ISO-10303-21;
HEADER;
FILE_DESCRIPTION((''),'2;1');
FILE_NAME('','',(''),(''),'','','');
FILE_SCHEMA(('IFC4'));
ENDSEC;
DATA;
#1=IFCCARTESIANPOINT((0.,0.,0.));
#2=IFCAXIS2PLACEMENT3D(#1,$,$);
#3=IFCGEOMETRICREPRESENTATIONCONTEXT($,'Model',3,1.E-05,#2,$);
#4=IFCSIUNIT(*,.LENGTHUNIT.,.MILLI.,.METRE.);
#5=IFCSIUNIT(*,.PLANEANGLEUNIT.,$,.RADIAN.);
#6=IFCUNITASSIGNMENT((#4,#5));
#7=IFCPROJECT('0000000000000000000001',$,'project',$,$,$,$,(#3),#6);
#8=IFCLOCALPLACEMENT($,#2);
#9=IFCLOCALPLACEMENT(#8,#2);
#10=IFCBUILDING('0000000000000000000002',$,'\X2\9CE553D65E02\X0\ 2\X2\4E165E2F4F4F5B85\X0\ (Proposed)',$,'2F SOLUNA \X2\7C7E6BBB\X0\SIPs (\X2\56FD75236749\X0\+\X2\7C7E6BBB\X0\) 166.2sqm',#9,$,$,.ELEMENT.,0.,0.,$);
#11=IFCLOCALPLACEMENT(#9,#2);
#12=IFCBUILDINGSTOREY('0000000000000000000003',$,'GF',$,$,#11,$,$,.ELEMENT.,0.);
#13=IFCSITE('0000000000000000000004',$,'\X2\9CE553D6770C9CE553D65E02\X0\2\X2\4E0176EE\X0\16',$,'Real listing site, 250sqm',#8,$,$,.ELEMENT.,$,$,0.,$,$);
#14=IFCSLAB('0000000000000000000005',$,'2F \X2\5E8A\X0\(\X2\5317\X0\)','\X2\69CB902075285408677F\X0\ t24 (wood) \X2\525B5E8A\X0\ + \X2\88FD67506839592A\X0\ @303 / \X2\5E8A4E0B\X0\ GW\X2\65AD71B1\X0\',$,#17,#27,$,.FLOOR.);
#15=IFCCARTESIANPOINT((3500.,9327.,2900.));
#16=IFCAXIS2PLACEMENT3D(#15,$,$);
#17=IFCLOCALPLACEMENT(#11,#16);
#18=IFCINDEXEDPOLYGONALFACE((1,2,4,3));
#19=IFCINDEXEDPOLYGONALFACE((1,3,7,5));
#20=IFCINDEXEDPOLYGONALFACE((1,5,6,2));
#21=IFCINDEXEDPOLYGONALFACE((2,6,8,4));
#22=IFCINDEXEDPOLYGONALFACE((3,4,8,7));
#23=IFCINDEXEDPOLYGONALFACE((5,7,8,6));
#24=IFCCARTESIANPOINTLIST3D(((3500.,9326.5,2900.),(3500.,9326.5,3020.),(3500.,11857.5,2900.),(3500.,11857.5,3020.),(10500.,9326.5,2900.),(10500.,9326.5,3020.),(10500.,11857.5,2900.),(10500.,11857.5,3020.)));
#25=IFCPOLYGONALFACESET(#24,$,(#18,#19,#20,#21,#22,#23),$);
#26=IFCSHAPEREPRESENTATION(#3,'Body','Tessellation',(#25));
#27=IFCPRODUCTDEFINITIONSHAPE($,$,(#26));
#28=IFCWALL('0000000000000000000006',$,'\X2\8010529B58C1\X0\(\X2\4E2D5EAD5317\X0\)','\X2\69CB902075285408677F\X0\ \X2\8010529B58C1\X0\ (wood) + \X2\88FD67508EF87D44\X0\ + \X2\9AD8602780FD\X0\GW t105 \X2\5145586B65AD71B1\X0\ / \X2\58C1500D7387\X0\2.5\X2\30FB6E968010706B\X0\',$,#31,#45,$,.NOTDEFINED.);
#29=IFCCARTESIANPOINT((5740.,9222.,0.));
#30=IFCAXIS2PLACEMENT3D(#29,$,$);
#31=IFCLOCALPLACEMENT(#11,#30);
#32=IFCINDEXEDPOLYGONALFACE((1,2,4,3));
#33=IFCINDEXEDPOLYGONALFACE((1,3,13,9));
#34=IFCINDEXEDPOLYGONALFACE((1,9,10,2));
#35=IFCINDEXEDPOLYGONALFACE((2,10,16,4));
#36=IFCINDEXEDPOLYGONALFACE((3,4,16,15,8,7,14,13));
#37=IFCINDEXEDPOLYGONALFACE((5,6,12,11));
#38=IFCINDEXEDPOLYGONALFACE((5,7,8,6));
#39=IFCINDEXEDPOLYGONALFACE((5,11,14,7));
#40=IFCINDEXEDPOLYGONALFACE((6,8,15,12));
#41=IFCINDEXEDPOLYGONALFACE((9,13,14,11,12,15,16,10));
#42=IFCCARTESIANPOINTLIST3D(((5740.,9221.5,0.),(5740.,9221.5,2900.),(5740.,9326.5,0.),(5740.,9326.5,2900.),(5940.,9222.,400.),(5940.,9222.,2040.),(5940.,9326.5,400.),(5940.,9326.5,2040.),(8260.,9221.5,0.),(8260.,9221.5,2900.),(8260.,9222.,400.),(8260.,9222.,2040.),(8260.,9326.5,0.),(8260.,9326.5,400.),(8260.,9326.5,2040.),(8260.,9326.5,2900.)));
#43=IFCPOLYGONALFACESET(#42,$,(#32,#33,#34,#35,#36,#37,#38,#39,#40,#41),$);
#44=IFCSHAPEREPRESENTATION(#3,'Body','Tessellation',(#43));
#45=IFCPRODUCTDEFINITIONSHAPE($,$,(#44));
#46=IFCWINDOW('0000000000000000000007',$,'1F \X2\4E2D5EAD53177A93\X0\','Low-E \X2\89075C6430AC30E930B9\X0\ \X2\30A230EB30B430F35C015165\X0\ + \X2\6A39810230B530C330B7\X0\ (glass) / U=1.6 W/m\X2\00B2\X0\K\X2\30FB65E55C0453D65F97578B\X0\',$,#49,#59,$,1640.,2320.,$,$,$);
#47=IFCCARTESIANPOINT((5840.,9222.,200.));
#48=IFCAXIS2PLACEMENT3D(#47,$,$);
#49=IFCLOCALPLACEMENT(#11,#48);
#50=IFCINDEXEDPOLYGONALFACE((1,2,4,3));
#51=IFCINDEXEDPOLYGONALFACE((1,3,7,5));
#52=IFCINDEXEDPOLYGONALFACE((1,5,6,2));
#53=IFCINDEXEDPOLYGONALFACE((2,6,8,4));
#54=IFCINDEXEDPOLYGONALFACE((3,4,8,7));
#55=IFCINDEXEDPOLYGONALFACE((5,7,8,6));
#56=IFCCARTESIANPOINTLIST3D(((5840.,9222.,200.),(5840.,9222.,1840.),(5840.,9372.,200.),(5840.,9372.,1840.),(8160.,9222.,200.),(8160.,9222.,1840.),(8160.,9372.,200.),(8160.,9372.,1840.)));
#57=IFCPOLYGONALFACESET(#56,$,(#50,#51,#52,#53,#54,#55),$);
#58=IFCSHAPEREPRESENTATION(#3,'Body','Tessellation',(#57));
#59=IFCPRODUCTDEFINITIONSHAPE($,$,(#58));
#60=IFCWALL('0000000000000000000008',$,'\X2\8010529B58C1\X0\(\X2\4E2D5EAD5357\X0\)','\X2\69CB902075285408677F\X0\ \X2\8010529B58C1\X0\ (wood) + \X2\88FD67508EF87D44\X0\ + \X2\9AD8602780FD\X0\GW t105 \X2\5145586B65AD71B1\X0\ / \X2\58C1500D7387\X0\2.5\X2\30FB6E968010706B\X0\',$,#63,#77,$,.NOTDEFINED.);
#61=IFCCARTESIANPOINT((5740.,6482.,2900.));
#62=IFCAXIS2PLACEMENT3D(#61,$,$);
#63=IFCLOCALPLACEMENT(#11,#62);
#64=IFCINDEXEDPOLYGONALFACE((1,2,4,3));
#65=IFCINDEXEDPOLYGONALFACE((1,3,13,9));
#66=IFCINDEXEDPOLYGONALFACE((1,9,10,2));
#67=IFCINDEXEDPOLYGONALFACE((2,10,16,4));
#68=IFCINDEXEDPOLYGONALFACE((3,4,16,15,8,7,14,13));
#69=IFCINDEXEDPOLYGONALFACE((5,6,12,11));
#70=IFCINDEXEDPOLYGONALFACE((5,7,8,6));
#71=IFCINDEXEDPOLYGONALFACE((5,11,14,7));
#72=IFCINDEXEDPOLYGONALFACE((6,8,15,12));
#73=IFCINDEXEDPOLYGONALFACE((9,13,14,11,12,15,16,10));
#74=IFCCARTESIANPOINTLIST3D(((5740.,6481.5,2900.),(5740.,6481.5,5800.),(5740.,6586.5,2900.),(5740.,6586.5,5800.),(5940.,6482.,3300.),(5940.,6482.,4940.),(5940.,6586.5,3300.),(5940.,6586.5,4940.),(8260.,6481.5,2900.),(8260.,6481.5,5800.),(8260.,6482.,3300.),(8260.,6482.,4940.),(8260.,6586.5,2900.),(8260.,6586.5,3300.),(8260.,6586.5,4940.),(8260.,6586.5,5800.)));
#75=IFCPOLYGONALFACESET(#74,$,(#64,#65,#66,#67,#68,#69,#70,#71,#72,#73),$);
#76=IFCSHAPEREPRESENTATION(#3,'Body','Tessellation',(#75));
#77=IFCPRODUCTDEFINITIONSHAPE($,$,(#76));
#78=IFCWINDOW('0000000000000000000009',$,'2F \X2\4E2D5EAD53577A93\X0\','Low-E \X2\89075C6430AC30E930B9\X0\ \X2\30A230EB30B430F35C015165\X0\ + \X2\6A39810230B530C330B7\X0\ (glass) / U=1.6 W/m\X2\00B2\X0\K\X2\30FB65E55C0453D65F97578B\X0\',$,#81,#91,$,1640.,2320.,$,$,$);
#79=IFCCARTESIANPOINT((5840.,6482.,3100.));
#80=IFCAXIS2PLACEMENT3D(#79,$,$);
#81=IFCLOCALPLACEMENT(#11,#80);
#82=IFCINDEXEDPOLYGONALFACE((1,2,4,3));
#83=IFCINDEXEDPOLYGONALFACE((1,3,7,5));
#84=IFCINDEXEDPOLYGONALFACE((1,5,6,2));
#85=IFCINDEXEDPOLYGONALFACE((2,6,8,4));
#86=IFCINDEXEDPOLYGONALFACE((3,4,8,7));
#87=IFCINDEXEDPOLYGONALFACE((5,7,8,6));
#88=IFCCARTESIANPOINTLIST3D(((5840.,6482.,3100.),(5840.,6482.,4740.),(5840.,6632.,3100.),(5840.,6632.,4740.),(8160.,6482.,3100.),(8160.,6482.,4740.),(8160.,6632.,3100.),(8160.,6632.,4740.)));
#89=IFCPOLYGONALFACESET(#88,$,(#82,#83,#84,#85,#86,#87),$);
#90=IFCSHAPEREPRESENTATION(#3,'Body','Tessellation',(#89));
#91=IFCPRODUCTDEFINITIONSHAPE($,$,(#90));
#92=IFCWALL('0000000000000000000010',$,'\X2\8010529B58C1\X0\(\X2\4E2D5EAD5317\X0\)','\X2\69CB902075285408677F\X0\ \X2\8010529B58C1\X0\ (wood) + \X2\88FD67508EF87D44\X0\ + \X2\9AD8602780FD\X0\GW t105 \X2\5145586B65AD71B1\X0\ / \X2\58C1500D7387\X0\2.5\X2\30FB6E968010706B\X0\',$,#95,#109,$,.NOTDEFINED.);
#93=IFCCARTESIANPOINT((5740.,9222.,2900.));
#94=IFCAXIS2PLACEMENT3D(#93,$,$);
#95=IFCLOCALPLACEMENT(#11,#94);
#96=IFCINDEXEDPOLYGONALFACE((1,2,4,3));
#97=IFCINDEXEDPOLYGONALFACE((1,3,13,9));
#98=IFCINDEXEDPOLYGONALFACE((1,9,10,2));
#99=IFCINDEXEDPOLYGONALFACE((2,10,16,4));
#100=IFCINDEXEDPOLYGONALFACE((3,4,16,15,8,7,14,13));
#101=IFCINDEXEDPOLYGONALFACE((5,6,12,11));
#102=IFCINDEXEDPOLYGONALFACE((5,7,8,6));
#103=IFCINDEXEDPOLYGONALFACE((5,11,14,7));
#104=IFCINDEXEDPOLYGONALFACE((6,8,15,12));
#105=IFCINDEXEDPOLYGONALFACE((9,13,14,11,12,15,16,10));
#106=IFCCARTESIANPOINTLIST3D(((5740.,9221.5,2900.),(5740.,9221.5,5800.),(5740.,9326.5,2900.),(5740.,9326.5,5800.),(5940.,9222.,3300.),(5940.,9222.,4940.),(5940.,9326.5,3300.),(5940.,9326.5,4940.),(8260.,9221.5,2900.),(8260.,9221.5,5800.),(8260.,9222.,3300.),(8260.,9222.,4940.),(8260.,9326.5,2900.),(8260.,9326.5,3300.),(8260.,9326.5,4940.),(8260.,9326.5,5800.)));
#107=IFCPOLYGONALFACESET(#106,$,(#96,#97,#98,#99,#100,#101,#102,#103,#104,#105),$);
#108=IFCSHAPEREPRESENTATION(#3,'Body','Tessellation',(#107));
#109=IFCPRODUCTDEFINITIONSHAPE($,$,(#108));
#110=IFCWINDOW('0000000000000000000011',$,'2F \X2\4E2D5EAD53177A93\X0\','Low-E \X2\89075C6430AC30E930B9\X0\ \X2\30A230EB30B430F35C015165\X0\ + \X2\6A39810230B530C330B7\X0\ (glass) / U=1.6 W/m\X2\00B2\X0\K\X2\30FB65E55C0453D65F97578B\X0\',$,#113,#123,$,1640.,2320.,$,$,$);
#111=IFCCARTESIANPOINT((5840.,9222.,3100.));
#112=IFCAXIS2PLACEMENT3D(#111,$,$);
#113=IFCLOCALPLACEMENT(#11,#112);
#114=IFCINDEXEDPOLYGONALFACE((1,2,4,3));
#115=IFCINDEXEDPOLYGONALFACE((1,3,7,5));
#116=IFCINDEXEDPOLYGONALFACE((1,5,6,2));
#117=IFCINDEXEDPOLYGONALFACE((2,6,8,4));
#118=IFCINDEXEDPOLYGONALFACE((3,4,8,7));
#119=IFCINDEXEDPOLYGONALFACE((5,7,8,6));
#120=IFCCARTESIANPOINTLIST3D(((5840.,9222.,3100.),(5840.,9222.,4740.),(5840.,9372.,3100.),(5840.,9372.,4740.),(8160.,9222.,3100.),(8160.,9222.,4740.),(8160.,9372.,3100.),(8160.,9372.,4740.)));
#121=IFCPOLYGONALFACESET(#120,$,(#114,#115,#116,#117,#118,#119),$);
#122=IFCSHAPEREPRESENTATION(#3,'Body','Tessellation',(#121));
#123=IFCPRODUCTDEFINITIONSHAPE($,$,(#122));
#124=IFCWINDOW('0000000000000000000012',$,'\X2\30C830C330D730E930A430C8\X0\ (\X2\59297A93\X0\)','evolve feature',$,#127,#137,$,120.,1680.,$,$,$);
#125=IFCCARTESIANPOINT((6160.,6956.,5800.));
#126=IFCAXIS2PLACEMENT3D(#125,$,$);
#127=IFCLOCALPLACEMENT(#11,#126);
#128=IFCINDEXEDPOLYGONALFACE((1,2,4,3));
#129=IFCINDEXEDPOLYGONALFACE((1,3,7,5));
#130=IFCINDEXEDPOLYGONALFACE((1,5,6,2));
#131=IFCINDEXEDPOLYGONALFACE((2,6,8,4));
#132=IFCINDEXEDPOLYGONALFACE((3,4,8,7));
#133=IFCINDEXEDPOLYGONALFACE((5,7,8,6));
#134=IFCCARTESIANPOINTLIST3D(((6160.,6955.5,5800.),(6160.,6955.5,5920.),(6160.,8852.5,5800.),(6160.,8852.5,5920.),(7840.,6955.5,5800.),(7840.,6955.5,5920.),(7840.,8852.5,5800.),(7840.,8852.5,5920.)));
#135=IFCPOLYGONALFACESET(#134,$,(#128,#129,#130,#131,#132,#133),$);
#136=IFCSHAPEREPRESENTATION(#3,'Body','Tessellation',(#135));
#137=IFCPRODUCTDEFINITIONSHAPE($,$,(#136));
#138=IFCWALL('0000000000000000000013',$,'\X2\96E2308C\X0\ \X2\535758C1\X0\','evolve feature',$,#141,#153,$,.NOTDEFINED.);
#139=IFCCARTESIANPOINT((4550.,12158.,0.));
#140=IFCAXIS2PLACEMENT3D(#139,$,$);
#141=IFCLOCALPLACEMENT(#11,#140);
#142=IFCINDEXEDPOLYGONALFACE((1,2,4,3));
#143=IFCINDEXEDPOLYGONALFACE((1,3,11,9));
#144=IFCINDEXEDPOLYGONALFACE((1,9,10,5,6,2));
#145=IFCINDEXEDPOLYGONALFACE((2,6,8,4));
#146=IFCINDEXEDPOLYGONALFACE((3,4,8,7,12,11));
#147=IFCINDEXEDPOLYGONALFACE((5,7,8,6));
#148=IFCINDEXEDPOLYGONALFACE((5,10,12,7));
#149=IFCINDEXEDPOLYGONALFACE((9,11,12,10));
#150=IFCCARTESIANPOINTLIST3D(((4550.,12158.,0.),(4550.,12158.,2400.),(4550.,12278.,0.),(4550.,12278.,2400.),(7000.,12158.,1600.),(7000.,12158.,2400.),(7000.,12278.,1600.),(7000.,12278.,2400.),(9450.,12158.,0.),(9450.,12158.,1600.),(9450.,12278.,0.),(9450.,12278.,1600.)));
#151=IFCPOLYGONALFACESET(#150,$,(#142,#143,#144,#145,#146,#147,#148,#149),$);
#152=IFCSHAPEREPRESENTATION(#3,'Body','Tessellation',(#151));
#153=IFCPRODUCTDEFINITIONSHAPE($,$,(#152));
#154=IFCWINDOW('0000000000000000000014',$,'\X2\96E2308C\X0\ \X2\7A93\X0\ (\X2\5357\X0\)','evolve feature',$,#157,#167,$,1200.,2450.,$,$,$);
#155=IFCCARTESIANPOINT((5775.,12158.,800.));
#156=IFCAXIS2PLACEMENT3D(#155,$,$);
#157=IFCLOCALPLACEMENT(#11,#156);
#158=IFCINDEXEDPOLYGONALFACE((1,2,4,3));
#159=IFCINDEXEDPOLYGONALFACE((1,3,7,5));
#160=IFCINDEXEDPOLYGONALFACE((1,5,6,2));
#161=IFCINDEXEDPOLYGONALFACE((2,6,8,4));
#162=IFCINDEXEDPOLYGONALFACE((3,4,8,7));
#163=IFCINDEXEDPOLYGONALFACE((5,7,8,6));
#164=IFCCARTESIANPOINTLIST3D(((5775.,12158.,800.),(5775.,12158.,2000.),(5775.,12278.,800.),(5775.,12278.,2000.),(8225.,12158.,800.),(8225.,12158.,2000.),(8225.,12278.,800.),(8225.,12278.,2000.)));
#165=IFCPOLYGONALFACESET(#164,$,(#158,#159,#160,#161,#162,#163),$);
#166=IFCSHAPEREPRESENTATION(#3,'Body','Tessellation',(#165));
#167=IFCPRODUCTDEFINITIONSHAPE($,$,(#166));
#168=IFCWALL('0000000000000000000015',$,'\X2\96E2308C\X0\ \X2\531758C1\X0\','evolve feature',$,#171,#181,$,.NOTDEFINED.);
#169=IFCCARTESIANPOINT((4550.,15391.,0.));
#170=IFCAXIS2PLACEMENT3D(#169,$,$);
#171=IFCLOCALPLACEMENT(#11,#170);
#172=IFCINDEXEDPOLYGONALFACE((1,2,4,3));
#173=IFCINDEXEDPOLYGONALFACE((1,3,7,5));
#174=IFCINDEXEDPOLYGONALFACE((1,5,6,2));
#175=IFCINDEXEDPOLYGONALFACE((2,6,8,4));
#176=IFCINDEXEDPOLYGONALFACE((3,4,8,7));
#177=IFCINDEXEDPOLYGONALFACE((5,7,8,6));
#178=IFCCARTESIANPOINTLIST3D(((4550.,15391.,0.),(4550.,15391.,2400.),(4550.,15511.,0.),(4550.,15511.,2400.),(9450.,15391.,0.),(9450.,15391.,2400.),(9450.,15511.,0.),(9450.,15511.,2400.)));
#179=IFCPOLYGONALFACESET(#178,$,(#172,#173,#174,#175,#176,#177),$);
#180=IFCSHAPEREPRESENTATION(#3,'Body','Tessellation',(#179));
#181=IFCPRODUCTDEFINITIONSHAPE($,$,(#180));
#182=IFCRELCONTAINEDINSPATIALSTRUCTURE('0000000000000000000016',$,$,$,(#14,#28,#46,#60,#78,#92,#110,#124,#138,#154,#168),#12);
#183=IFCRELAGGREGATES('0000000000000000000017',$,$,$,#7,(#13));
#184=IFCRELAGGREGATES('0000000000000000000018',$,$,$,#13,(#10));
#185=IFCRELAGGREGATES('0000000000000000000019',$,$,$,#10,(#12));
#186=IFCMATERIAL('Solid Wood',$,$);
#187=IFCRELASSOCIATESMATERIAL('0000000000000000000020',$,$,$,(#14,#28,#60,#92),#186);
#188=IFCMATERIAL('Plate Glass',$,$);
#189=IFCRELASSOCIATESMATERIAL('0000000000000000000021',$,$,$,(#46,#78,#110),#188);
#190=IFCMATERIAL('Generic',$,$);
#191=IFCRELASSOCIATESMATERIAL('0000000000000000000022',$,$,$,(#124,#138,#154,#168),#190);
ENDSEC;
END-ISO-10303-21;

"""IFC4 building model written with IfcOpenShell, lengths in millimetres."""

from ifc_helpers import new_model, si_unit, frame, frame_2d, origin, place, context, project, spatial, rectangle, extrude, material, element, fill, save


model = new_model("IFC4")

# Units and contexts
model_context = context("Model", 3, precision=1e-05, world=origin())
ifc_project = project(units=[si_unit("LENGTHUNIT", "METRE", prefix="MILLI"), si_unit("PLANEANGLEUNIT", "RADIAN")], contexts=[model_context])

# Site, building, storey
site_placement = place(None, origin())
site = spatial("IfcSite", under=ifc_project, at=site_placement, Name="鳥取県鳥取市2丁目16", ObjectType="Real listing site, 250sqm", CompositionType="ELEMENT", RefElevation=0.0)
building_placement = place(site_placement, origin())
building = spatial("IfcBuilding", under=site, at=building_placement, Name="鳥取市 2世帯住宅 (Proposed)", ObjectType="2F SOLUNA 籾殻SIPs (国産杉+籾殻) 166.2sqm", CompositionType="ELEMENT", ElevationOfRefHeight=0.0, ElevationOfTerrain=0.0)
storey_placement = place(building_placement, origin())
storey = spatial("IfcBuildingStorey", under=building, at=storey_placement, Name="GF", CompositionType="ELEMENT", Elevation=0.0)

# Slab
ifc_material_1 = material(Name="Solid Wood")
slab_1_placement = place(storey_placement, frame((3500.0, 9327.0, 2900.0)))
element("IfcSlab", 1, at=slab_1_placement, inside=storey, material=ifc_material_1, Name="2F 床(北)", Description="構造用合板 t24 (wood) 剛床 + 製材根太 @303 / 床下 GW断熱", PredefinedType="FLOOR", context=model_context, shape_type="SweptSolid", body=[
    extrude(rectangle(XDim=7000.0, YDim=2531.0, at=frame_2d((3500.0, 1265.0))), frame((3500.0, 9327.0, 2900.0)), (0.0, 0.0, 1.0), 120.0),
])
ifc_material_2 = material(Name="Generic")

# Wall, opening, window
wall_1_placement = place(storey_placement, frame((5740.0, 9222.0, 0.0)))
wall_1 = element("IfcWall", 2, at=wall_1_placement, inside=storey, material=ifc_material_1, Name="耐力壁(中庭北)", Description="構造用合板 耐力壁 (wood) + 製材軸組 + 高性能GW t105 充填断熱 / 壁倍率2.5・準耐火", PredefinedType="NOTDEFINED", context=model_context, shape_type="SweptSolid", body=[
    extrude(rectangle(XDim=2520.0, YDim=105.0, at=frame_2d((1260.0, 52.0))), frame((5740.0, 9222.0, 0.0)), (0.0, 0.0, 1.0), 2900.0),
])
opening_1_placement = place(storey_placement, frame((5840.0, 9222.0, 200.0)))
opening_1 = element("IfcOpeningElement", 3, at=opening_1_placement, cuts=wall_1, PredefinedType="NOTDEFINED", context=model_context, shape_type="SweptSolid", body=[
    extrude(rectangle(XDim=2320.0, YDim=150.0, at=frame_2d((1160.0, 75.0))), frame((5840.0, 9222.0, 200.0)), (0.0, 0.0, 1.0), 1640.0),
])
ifc_material_3 = material(Name="Plate Glass")
window_1_placement = place(storey_placement, frame((5840.0, 9222.0, 200.0)))
window_1 = element("IfcWindow", 4, at=window_1_placement, inside=storey, material=ifc_material_3, Name="1F 中庭北窓", Description="Low-E 複層ガラス アルゴン封入 + 樹脂サッシ (glass) / U=1.6 W/m²K・日射取得型", OverallHeight=1640.0, OverallWidth=2320.0, context=model_context, shape_type="SweptSolid", body=[
    extrude(rectangle(XDim=2320.0, YDim=150.0, at=frame_2d((1160.0, 75.0))), frame((5840.0, 9222.0, 200.0)), (0.0, 0.0, 1.0), 1640.0),
])
fill(opening_1, window_1)

# Walls, openings, windows
wall_2_placement = place(storey_placement, frame((5740.0, 6482.0, 2900.0)))
wall_2 = element("IfcWall", 5, at=wall_2_placement, inside=storey, material=ifc_material_1, Name="耐力壁(中庭南)", Description="構造用合板 耐力壁 (wood) + 製材軸組 + 高性能GW t105 充填断熱 / 壁倍率2.5・準耐火", PredefinedType="NOTDEFINED", context=model_context, shape_type="SweptSolid", body=[
    extrude(rectangle(XDim=2520.0, YDim=105.0, at=frame_2d((1260.0, 52.0))), frame((5740.0, 6482.0, 2900.0)), (0.0, 0.0, 1.0), 2900.0),
])
opening_2_placement = place(storey_placement, frame((5840.0, 6482.0, 3100.0)))
opening_2 = element("IfcOpeningElement", 6, at=opening_2_placement, cuts=wall_2, PredefinedType="NOTDEFINED", context=model_context, shape_type="SweptSolid", body=[
    extrude(rectangle(XDim=2320.0, YDim=150.0, at=frame_2d((1160.0, 75.0))), frame((5840.0, 6482.0, 3100.0)), (0.0, 0.0, 1.0), 1640.0),
])
window_2_placement = place(storey_placement, frame((5840.0, 6482.0, 3100.0)))
window_2 = element("IfcWindow", 7, at=window_2_placement, inside=storey, material=ifc_material_3, Name="2F 中庭南窓", Description="Low-E 複層ガラス アルゴン封入 + 樹脂サッシ (glass) / U=1.6 W/m²K・日射取得型", OverallHeight=1640.0, OverallWidth=2320.0, context=model_context, shape_type="SweptSolid", body=[
    extrude(rectangle(XDim=2320.0, YDim=150.0, at=frame_2d((1160.0, 75.0))), frame((5840.0, 6482.0, 3100.0)), (0.0, 0.0, 1.0), 1640.0),
])
fill(opening_2, window_2)
wall_3_placement = place(storey_placement, frame((5740.0, 9222.0, 2900.0)))
wall_3 = element("IfcWall", 8, at=wall_3_placement, inside=storey, material=ifc_material_1, Name="耐力壁(中庭北)", Description="構造用合板 耐力壁 (wood) + 製材軸組 + 高性能GW t105 充填断熱 / 壁倍率2.5・準耐火", PredefinedType="NOTDEFINED", context=model_context, shape_type="SweptSolid", body=[
    extrude(rectangle(XDim=2520.0, YDim=105.0, at=frame_2d((1260.0, 52.0))), frame((5740.0, 9222.0, 2900.0)), (0.0, 0.0, 1.0), 2900.0),
])
opening_3_placement = place(storey_placement, frame((5840.0, 9222.0, 3100.0)))
opening_3 = element("IfcOpeningElement", 9, at=opening_3_placement, cuts=wall_3, PredefinedType="NOTDEFINED", context=model_context, shape_type="SweptSolid", body=[
    extrude(rectangle(XDim=2320.0, YDim=150.0, at=frame_2d((1160.0, 75.0))), frame((5840.0, 9222.0, 3100.0)), (0.0, 0.0, 1.0), 1640.0),
])
window_3_placement = place(storey_placement, frame((5840.0, 9222.0, 3100.0)))
window_3 = element("IfcWindow", 10, at=window_3_placement, inside=storey, material=ifc_material_3, Name="2F 中庭北窓", Description="Low-E 複層ガラス アルゴン封入 + 樹脂サッシ (glass) / U=1.6 W/m²K・日射取得型", OverallHeight=1640.0, OverallWidth=2320.0, context=model_context, shape_type="SweptSolid", body=[
    extrude(rectangle(XDim=2320.0, YDim=150.0, at=frame_2d((1160.0, 75.0))), frame((5840.0, 9222.0, 3100.0)), (0.0, 0.0, 1.0), 1640.0),
])
fill(opening_3, window_3)

# Window
window_4_placement = place(storey_placement, frame((6160.0, 6956.0, 5800.0)))
element("IfcWindow", 11, at=window_4_placement, inside=storey, material=ifc_material_2, Name="トップライト (天窓)", Description="evolve feature", OverallHeight=120.0, OverallWidth=1680.0, context=model_context, shape_type="SweptSolid", body=[
    extrude(rectangle(XDim=1680.0, YDim=1897.0, at=frame_2d((840.0, 948.0))), frame((6160.0, 6956.0, 5800.0)), (0.0, 0.0, 1.0), 120.0),
])

# Wall, opening, window
wall_4_placement = place(storey_placement, frame((4550.0, 12158.0, 0.0)))
wall_4 = element("IfcWall", 12, at=wall_4_placement, inside=storey, material=ifc_material_2, Name="離れ 南壁", Description="evolve feature", PredefinedType="NOTDEFINED", context=model_context, shape_type="SweptSolid", body=[
    extrude(rectangle(XDim=4900.0, YDim=120.0, at=frame_2d((2450.0, 60.0))), frame((4550.0, 12158.0, 0.0)), (0.0, 0.0, 1.0), 2400.0),
])
opening_4_placement = place(storey_placement, frame((5775.0, 12158.0, 800.0)))
opening_4 = element("IfcOpeningElement", 13, at=opening_4_placement, cuts=wall_4, PredefinedType="NOTDEFINED", context=model_context, shape_type="SweptSolid", body=[
    extrude(rectangle(XDim=2450.0, YDim=120.0, at=frame_2d((1225.0, 60.0))), frame((5775.0, 12158.0, 800.0)), (0.0, 0.0, 1.0), 1200.0),
])
window_5_placement = place(storey_placement, frame((5775.0, 12158.0, 800.0)))
window_5 = element("IfcWindow", 14, at=window_5_placement, inside=storey, material=ifc_material_2, Name="離れ 窓 (南)", Description="evolve feature", OverallHeight=1200.0, OverallWidth=2450.0, context=model_context, shape_type="SweptSolid", body=[
    extrude(rectangle(XDim=2450.0, YDim=120.0, at=frame_2d((1225.0, 60.0))), frame((5775.0, 12158.0, 800.0)), (0.0, 0.0, 1.0), 1200.0),
])
fill(opening_4, window_5)

# Wall
wall_5_placement = place(storey_placement, frame((4550.0, 15391.0, 0.0)))
element("IfcWall", 15, at=wall_5_placement, inside=storey, material=ifc_material_2, Name="離れ 北壁", Description="evolve feature", PredefinedType="NOTDEFINED", context=model_context, shape_type="SweptSolid", body=[
    extrude(rectangle(XDim=4900.0, YDim=120.0, at=frame_2d((2450.0, 60.0))), frame((4550.0, 15391.0, 0.0)), (0.0, 0.0, 1.0), 2400.0),
])

save(model, "model.ifc")
